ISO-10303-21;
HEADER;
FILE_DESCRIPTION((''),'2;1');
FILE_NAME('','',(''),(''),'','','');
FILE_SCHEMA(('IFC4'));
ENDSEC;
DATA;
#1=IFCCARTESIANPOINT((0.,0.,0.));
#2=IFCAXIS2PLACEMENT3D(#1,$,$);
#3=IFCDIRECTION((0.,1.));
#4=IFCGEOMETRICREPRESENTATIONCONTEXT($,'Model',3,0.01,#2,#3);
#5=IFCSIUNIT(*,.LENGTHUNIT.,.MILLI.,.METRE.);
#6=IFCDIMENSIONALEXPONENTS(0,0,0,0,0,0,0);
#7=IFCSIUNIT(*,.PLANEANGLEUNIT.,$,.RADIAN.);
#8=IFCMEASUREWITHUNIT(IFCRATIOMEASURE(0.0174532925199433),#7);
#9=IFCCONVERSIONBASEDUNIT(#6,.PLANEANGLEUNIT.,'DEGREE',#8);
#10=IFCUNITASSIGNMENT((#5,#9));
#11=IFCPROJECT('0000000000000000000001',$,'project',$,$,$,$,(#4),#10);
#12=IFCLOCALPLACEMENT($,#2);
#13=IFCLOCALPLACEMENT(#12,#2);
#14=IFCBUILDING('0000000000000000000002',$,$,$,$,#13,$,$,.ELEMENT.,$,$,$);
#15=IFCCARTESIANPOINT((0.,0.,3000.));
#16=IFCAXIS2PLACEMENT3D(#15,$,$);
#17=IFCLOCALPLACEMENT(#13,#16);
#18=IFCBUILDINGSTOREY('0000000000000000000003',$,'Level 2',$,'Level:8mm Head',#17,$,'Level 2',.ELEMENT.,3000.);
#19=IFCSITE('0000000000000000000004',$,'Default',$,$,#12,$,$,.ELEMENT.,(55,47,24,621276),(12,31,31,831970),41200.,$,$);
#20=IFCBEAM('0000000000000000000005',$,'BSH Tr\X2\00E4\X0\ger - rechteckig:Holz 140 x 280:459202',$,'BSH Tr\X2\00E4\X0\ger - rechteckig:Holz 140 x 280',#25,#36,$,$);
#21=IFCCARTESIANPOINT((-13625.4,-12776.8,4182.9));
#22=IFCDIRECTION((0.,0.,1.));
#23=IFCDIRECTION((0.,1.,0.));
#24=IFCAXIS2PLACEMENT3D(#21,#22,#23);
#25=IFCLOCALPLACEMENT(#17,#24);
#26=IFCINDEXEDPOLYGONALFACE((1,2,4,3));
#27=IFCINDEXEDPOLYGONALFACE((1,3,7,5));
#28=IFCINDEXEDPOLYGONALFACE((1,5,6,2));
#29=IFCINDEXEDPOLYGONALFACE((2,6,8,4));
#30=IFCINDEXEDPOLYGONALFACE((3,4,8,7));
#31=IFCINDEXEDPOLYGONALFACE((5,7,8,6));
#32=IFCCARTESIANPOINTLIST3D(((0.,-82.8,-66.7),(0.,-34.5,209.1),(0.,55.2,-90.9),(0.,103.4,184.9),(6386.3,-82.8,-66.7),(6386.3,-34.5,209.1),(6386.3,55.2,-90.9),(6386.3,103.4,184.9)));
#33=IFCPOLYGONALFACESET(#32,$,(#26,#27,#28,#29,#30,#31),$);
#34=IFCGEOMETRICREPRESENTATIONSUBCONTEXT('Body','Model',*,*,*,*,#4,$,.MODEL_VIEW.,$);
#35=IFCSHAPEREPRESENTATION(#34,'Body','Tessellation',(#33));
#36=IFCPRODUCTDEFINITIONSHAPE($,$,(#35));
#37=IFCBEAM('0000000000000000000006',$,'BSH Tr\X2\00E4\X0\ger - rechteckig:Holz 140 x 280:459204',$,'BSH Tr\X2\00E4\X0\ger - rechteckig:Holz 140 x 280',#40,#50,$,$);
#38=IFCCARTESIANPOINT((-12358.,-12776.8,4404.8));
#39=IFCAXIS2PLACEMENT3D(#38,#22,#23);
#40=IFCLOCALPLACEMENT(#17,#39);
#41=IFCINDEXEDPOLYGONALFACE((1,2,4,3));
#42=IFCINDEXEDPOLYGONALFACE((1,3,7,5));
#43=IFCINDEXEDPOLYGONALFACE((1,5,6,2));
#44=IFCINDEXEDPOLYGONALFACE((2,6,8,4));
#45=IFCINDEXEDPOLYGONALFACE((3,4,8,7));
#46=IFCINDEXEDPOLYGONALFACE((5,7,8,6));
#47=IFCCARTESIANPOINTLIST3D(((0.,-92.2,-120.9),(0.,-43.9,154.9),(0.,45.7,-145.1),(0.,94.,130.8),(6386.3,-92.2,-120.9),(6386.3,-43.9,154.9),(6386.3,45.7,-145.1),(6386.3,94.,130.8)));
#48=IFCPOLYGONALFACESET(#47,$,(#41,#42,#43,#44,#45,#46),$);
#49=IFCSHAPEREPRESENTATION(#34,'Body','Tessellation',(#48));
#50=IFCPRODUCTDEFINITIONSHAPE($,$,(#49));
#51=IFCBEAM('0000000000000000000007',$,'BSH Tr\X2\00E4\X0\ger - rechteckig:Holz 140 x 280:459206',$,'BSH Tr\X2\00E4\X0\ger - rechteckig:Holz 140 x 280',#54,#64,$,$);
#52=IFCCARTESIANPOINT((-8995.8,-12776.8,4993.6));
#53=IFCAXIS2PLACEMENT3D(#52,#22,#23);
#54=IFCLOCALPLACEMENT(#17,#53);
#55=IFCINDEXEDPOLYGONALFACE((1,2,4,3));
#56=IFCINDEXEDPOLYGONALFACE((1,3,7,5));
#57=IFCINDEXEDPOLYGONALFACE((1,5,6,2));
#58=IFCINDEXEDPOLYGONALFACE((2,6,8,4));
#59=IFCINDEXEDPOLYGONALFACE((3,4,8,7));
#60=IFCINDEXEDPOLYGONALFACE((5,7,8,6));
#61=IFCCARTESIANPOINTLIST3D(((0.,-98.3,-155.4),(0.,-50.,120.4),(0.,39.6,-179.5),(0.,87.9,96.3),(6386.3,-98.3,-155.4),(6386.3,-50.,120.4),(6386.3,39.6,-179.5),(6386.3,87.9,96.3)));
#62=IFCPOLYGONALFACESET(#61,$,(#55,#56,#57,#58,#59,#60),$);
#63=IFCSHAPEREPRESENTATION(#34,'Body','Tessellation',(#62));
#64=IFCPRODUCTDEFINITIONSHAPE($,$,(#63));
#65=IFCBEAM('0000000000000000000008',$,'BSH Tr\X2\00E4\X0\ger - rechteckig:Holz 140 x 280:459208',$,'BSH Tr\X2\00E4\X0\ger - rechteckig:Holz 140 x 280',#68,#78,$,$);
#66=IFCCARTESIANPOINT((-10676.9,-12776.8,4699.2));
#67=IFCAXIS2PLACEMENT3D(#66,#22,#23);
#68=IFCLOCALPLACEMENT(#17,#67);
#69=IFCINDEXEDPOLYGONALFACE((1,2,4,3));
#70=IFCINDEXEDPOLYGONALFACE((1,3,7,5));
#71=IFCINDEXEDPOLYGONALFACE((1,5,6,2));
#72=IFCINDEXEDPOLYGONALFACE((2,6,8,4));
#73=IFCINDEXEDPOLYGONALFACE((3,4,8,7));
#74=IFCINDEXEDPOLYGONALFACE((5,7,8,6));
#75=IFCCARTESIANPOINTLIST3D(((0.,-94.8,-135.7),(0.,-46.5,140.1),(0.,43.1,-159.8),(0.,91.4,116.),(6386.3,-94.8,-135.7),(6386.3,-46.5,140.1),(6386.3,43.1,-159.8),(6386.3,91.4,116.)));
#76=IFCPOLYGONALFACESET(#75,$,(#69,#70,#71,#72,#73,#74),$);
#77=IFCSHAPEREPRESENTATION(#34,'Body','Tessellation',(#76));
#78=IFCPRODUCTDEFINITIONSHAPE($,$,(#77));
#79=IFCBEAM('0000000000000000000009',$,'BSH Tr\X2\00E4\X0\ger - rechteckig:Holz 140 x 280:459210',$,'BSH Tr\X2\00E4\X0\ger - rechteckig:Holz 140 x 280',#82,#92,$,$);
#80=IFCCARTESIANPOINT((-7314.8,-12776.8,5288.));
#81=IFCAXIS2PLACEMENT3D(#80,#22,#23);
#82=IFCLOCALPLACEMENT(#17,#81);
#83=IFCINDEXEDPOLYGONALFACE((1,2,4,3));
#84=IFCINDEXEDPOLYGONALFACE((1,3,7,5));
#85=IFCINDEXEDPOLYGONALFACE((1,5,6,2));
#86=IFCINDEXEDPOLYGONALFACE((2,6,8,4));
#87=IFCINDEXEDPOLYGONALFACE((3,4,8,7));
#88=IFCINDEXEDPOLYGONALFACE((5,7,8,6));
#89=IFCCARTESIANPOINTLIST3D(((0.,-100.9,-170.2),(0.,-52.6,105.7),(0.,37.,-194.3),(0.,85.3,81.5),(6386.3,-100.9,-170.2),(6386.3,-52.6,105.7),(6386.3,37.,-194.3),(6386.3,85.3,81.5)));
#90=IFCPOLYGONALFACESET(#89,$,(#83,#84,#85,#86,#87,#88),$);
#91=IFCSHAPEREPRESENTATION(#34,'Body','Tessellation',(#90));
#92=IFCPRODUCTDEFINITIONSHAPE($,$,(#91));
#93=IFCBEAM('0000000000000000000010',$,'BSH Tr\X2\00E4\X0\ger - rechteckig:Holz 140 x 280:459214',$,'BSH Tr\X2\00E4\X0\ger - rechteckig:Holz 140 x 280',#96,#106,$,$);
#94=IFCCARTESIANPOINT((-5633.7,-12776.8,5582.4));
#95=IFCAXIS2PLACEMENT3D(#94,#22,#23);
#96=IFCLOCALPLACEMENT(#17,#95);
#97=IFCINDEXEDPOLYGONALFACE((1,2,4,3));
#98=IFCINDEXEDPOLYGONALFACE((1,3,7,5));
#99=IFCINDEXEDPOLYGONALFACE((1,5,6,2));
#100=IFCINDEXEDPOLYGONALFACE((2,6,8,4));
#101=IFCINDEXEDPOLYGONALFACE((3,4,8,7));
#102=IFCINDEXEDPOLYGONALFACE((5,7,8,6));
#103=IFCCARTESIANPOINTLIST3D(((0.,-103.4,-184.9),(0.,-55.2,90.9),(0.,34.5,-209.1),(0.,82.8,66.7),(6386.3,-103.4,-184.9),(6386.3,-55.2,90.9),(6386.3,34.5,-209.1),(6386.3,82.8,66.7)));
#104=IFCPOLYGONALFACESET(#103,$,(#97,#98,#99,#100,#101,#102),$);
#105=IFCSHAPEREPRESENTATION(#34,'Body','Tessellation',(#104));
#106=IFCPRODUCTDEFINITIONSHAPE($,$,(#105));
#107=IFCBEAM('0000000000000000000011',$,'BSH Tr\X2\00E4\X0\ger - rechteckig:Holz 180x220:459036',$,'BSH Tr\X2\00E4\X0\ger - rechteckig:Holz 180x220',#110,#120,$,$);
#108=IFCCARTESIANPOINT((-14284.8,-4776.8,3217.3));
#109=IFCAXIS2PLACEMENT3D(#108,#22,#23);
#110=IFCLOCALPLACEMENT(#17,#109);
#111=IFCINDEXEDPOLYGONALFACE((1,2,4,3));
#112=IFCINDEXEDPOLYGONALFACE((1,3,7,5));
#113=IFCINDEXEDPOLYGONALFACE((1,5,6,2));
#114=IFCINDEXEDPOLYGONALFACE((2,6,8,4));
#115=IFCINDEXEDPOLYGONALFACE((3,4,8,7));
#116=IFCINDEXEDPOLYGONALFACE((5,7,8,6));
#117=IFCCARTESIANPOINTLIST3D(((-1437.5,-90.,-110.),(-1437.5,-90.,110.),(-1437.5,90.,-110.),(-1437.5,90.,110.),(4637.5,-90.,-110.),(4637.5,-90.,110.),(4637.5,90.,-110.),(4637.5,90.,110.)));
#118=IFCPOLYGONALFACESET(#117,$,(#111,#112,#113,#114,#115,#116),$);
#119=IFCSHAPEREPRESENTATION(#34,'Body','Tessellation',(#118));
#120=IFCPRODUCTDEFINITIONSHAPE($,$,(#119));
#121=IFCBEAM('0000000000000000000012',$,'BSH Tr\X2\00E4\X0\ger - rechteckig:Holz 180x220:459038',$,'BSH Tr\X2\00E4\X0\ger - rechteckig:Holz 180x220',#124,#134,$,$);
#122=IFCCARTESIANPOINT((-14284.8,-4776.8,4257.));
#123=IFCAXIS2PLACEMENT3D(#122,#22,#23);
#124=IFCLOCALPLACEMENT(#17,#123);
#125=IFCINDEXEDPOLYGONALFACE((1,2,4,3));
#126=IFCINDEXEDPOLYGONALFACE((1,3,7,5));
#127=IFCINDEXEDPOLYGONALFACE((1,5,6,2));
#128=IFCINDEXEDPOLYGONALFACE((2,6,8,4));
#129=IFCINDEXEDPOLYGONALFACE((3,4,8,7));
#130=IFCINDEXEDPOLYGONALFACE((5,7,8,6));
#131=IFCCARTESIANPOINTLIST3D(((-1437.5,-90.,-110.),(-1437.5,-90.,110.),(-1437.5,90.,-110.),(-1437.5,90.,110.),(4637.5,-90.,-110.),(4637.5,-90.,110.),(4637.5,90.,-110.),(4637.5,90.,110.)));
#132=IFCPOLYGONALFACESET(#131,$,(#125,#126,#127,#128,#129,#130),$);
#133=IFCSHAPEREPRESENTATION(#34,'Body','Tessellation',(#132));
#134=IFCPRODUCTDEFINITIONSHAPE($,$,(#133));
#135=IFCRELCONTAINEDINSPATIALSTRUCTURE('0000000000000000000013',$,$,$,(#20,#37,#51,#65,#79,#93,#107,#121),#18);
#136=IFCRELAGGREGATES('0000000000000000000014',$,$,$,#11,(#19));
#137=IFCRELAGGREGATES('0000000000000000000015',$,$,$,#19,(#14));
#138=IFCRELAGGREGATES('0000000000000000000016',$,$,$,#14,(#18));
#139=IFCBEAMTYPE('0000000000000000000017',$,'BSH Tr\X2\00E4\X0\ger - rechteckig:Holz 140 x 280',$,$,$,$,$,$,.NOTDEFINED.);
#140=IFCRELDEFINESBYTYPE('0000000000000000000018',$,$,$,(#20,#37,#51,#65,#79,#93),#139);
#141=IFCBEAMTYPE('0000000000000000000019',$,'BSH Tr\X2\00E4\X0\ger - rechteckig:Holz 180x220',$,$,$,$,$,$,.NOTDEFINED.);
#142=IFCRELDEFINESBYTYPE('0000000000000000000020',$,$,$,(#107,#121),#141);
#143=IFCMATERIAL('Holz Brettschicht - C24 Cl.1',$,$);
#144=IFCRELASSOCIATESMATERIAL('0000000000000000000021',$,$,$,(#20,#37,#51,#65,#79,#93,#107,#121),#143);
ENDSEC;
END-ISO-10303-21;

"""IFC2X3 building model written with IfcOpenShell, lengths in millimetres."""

from ifc_helpers import new_model, entity, si_unit, converted_unit, direction, frame, frame_2d, origin, origin_2d_with_axis, place, context, subcontext, project, spatial, rectangle, extrude, material, type_object, element, save


model = new_model("IFC2X3")

# Units and contexts
model_context = context("Model", 3, precision=0.01, world=origin(), true_north=direction((0.0, 1.0)))
body_context = subcontext(model_context, "Body", "Model", "MODEL_VIEW")
ifc_project = project(units=[si_unit("LENGTHUNIT", "METRE", prefix="MILLI"), converted_unit("PLANEANGLEUNIT", "DEGREE", entity("IfcRatioMeasure", 0.0174532925199433), si_unit("PLANEANGLEUNIT", "RADIAN"), dimensions=[0, 0, 0, 0, 0, 0, 0])], contexts=[model_context])

# Site, building, storey
site_placement = place(None, origin())
site = spatial("IfcSite", under=ifc_project, at=site_placement, Name="Default", CompositionType="ELEMENT", RefLatitude=(55, 47, 24, 621276), RefLongitude=(12, 31, 31, 831970), RefElevation=41200.0)
building_placement = place(site_placement, origin())
building = spatial("IfcBuilding", under=site, at=building_placement, CompositionType="ELEMENT")
storey_placement = place(building_placement, frame((0.0, 0.0, 3000.0)))
storey = spatial("IfcBuildingStorey", under=building, at=storey_placement, Name="Level 2", ObjectType="Level:8mm Head", LongName="Level 2", CompositionType="ELEMENT", Elevation=3000.0)

# Beams
ifc_material_1 = material(Name="Holz Brettschicht - C24 Cl.1")
beam_type_1 = type_object("IfcBeamType", Name="BSH Träger - rechteckig:Holz 140 x 280", PredefinedType="NOTDEFINED")
beam_1_placement = place(storey_placement, frame((-13625.4, -12776.8, 4182.9), z_axis=(0.0, 0.0, 1.0), x_axis=(0.0, 1.0, 0.0)))
element("IfcBeam", 1, at=beam_1_placement, inside=storey, type_object=beam_type_1, material=ifc_material_1, Name="BSH Träger - rechteckig:Holz 140 x 280:459202", ObjectType="BSH Träger - rechteckig:Holz 140 x 280", context=body_context, shape_type="SweptSolid", body=[
    extrude(rectangle(XDim=280.0, YDim=140.0, at=origin_2d_with_axis()), frame((0.0, 10.3, 59.1), z_axis=(1.0, 0.0, 0.0), x_axis=(0.0, 0.172491, 0.985011)), (0.0, 0.0, 1.0), 6386.3),
])
beam_2_placement = place(storey_placement, frame((-12358.0, -12776.8, 4404.8), z_axis=(0.0, 0.0, 1.0), x_axis=(0.0, 1.0, 0.0)))
element("IfcBeam", 2, at=beam_2_placement, inside=storey, type_object=beam_type_1, material=ifc_material_1, Name="BSH Träger - rechteckig:Holz 140 x 280:459204", ObjectType="BSH Träger - rechteckig:Holz 140 x 280", context=body_context, shape_type="SweptSolid", body=[
    extrude(rectangle(XDim=280.0, YDim=140.0, at=origin_2d_with_axis()), frame((0.0, 0.9, 4.9), z_axis=(1.0, 0.0, 0.0), x_axis=(0.0, 0.172491, 0.985011)), (0.0, 0.0, 1.0), 6386.3),
])
beam_3_placement = place(storey_placement, frame((-8995.8, -12776.8, 4993.6), z_axis=(0.0, 0.0, 1.0), x_axis=(0.0, 1.0, 0.0)))
element("IfcBeam", 3, at=beam_3_placement, inside=storey, type_object=beam_type_1, material=ifc_material_1, Name="BSH Träger - rechteckig:Holz 140 x 280:459206", ObjectType="BSH Träger - rechteckig:Holz 140 x 280", context=body_context, shape_type="SweptSolid", body=[
    extrude(rectangle(XDim=280.0, YDim=140.0, at=origin_2d_with_axis()), frame((0.0, -5.2, -29.6), z_axis=(1.0, 0.0, 0.0), x_axis=(0.0, 0.172491, 0.985011)), (0.0, 0.0, 1.0), 6386.3),
])
beam_4_placement = place(storey_placement, frame((-10676.9, -12776.8, 4699.2), z_axis=(0.0, 0.0, 1.0), x_axis=(0.0, 1.0, 0.0)))
element("IfcBeam", 4, at=beam_4_placement, inside=storey, type_object=beam_type_1, material=ifc_material_1, Name="BSH Träger - rechteckig:Holz 140 x 280:459208", ObjectType="BSH Träger - rechteckig:Holz 140 x 280", context=body_context, shape_type="SweptSolid", body=[
    extrude(rectangle(XDim=280.0, YDim=140.0, at=origin_2d_with_axis()), frame((0.0, -1.7, -9.9), z_axis=(1.0, 0.0, 0.0), x_axis=(0.0, 0.172491, 0.985011)), (0.0, 0.0, 1.0), 6386.3),
])
beam_5_placement = place(storey_placement, frame((-7314.8, -12776.8, 5288.0), z_axis=(0.0, 0.0, 1.0), x_axis=(0.0, 1.0, 0.0)))
element("IfcBeam", 5, at=beam_5_placement, inside=storey, type_object=beam_type_1, material=ifc_material_1, Name="BSH Träger - rechteckig:Holz 140 x 280:459210", ObjectType="BSH Träger - rechteckig:Holz 140 x 280", context=body_context, shape_type="SweptSolid", body=[
    extrude(rectangle(XDim=280.0, YDim=140.0, at=frame_2d((0.0, 0.0), x_axis=(1.0, 0.0))), frame((0.0, -7.8, -44.3), z_axis=(1.0, 0.0, 0.0), x_axis=(0.0, 0.172491, 0.985011)), (0.0, 0.0, 1.0), 6386.3),
])
beam_6_placement = place(storey_placement, frame((-5633.7, -12776.8, 5582.4), z_axis=(0.0, 0.0, 1.0), x_axis=(0.0, 1.0, 0.0)))
element("IfcBeam", 6, at=beam_6_placement, inside=storey, type_object=beam_type_1, material=ifc_material_1, Name="BSH Träger - rechteckig:Holz 140 x 280:459214", ObjectType="BSH Träger - rechteckig:Holz 140 x 280", context=body_context, shape_type="SweptSolid", body=[
    extrude(rectangle(XDim=280.0, YDim=140.0, at=origin_2d_with_axis()), frame((0.0, -10.3, -59.1), z_axis=(1.0, 0.0, 0.0), x_axis=(0.0, 0.172491, 0.985011)), (0.0, 0.0, 1.0), 6386.3),
])
beam_type_2 = type_object("IfcBeamType", Name="BSH Träger - rechteckig:Holz 180x220", PredefinedType="NOTDEFINED")
beam_7_placement = place(storey_placement, frame((-14284.8, -4776.8, 3217.3), z_axis=(0.0, 0.0, 1.0), x_axis=(0.0, 1.0, 0.0)))
element("IfcBeam", 7, at=beam_7_placement, inside=storey, type_object=beam_type_2, material=ifc_material_1, Name="BSH Träger - rechteckig:Holz 180x220:459036", ObjectType="BSH Träger - rechteckig:Holz 180x220", context=body_context, shape_type="SweptSolid", body=[
    extrude(rectangle(XDim=220.0, YDim=180.0, at=frame_2d((0.0, 0.0), x_axis=(1.0, 0.0))), frame((-1437.5, 0.0, 0.0), z_axis=(1.0, 0.0, 0.0), x_axis=(0.0, 0.0, -1.0)), (0.0, 0.0, 1.0), 6075.0),
])
beam_8_placement = place(storey_placement, frame((-14284.8, -4776.8, 4257.0), z_axis=(0.0, 0.0, 1.0), x_axis=(0.0, 1.0, 0.0)))
element("IfcBeam", 8, at=beam_8_placement, inside=storey, type_object=beam_type_2, material=ifc_material_1, Name="BSH Träger - rechteckig:Holz 180x220:459038", ObjectType="BSH Träger - rechteckig:Holz 180x220", context=body_context, shape_type="SweptSolid", body=[
    extrude(rectangle(XDim=220.0, YDim=180.0, at=frame_2d((0.0, 0.0), x_axis=(1.0, 0.0))), frame((-1437.5, 0.0, 0.0), z_axis=(1.0, 0.0, 0.0), x_axis=(0.0, 0.0, -1.0)), (0.0, 0.0, 1.0), 6075.0),
])

save(model, "model.ifc")
